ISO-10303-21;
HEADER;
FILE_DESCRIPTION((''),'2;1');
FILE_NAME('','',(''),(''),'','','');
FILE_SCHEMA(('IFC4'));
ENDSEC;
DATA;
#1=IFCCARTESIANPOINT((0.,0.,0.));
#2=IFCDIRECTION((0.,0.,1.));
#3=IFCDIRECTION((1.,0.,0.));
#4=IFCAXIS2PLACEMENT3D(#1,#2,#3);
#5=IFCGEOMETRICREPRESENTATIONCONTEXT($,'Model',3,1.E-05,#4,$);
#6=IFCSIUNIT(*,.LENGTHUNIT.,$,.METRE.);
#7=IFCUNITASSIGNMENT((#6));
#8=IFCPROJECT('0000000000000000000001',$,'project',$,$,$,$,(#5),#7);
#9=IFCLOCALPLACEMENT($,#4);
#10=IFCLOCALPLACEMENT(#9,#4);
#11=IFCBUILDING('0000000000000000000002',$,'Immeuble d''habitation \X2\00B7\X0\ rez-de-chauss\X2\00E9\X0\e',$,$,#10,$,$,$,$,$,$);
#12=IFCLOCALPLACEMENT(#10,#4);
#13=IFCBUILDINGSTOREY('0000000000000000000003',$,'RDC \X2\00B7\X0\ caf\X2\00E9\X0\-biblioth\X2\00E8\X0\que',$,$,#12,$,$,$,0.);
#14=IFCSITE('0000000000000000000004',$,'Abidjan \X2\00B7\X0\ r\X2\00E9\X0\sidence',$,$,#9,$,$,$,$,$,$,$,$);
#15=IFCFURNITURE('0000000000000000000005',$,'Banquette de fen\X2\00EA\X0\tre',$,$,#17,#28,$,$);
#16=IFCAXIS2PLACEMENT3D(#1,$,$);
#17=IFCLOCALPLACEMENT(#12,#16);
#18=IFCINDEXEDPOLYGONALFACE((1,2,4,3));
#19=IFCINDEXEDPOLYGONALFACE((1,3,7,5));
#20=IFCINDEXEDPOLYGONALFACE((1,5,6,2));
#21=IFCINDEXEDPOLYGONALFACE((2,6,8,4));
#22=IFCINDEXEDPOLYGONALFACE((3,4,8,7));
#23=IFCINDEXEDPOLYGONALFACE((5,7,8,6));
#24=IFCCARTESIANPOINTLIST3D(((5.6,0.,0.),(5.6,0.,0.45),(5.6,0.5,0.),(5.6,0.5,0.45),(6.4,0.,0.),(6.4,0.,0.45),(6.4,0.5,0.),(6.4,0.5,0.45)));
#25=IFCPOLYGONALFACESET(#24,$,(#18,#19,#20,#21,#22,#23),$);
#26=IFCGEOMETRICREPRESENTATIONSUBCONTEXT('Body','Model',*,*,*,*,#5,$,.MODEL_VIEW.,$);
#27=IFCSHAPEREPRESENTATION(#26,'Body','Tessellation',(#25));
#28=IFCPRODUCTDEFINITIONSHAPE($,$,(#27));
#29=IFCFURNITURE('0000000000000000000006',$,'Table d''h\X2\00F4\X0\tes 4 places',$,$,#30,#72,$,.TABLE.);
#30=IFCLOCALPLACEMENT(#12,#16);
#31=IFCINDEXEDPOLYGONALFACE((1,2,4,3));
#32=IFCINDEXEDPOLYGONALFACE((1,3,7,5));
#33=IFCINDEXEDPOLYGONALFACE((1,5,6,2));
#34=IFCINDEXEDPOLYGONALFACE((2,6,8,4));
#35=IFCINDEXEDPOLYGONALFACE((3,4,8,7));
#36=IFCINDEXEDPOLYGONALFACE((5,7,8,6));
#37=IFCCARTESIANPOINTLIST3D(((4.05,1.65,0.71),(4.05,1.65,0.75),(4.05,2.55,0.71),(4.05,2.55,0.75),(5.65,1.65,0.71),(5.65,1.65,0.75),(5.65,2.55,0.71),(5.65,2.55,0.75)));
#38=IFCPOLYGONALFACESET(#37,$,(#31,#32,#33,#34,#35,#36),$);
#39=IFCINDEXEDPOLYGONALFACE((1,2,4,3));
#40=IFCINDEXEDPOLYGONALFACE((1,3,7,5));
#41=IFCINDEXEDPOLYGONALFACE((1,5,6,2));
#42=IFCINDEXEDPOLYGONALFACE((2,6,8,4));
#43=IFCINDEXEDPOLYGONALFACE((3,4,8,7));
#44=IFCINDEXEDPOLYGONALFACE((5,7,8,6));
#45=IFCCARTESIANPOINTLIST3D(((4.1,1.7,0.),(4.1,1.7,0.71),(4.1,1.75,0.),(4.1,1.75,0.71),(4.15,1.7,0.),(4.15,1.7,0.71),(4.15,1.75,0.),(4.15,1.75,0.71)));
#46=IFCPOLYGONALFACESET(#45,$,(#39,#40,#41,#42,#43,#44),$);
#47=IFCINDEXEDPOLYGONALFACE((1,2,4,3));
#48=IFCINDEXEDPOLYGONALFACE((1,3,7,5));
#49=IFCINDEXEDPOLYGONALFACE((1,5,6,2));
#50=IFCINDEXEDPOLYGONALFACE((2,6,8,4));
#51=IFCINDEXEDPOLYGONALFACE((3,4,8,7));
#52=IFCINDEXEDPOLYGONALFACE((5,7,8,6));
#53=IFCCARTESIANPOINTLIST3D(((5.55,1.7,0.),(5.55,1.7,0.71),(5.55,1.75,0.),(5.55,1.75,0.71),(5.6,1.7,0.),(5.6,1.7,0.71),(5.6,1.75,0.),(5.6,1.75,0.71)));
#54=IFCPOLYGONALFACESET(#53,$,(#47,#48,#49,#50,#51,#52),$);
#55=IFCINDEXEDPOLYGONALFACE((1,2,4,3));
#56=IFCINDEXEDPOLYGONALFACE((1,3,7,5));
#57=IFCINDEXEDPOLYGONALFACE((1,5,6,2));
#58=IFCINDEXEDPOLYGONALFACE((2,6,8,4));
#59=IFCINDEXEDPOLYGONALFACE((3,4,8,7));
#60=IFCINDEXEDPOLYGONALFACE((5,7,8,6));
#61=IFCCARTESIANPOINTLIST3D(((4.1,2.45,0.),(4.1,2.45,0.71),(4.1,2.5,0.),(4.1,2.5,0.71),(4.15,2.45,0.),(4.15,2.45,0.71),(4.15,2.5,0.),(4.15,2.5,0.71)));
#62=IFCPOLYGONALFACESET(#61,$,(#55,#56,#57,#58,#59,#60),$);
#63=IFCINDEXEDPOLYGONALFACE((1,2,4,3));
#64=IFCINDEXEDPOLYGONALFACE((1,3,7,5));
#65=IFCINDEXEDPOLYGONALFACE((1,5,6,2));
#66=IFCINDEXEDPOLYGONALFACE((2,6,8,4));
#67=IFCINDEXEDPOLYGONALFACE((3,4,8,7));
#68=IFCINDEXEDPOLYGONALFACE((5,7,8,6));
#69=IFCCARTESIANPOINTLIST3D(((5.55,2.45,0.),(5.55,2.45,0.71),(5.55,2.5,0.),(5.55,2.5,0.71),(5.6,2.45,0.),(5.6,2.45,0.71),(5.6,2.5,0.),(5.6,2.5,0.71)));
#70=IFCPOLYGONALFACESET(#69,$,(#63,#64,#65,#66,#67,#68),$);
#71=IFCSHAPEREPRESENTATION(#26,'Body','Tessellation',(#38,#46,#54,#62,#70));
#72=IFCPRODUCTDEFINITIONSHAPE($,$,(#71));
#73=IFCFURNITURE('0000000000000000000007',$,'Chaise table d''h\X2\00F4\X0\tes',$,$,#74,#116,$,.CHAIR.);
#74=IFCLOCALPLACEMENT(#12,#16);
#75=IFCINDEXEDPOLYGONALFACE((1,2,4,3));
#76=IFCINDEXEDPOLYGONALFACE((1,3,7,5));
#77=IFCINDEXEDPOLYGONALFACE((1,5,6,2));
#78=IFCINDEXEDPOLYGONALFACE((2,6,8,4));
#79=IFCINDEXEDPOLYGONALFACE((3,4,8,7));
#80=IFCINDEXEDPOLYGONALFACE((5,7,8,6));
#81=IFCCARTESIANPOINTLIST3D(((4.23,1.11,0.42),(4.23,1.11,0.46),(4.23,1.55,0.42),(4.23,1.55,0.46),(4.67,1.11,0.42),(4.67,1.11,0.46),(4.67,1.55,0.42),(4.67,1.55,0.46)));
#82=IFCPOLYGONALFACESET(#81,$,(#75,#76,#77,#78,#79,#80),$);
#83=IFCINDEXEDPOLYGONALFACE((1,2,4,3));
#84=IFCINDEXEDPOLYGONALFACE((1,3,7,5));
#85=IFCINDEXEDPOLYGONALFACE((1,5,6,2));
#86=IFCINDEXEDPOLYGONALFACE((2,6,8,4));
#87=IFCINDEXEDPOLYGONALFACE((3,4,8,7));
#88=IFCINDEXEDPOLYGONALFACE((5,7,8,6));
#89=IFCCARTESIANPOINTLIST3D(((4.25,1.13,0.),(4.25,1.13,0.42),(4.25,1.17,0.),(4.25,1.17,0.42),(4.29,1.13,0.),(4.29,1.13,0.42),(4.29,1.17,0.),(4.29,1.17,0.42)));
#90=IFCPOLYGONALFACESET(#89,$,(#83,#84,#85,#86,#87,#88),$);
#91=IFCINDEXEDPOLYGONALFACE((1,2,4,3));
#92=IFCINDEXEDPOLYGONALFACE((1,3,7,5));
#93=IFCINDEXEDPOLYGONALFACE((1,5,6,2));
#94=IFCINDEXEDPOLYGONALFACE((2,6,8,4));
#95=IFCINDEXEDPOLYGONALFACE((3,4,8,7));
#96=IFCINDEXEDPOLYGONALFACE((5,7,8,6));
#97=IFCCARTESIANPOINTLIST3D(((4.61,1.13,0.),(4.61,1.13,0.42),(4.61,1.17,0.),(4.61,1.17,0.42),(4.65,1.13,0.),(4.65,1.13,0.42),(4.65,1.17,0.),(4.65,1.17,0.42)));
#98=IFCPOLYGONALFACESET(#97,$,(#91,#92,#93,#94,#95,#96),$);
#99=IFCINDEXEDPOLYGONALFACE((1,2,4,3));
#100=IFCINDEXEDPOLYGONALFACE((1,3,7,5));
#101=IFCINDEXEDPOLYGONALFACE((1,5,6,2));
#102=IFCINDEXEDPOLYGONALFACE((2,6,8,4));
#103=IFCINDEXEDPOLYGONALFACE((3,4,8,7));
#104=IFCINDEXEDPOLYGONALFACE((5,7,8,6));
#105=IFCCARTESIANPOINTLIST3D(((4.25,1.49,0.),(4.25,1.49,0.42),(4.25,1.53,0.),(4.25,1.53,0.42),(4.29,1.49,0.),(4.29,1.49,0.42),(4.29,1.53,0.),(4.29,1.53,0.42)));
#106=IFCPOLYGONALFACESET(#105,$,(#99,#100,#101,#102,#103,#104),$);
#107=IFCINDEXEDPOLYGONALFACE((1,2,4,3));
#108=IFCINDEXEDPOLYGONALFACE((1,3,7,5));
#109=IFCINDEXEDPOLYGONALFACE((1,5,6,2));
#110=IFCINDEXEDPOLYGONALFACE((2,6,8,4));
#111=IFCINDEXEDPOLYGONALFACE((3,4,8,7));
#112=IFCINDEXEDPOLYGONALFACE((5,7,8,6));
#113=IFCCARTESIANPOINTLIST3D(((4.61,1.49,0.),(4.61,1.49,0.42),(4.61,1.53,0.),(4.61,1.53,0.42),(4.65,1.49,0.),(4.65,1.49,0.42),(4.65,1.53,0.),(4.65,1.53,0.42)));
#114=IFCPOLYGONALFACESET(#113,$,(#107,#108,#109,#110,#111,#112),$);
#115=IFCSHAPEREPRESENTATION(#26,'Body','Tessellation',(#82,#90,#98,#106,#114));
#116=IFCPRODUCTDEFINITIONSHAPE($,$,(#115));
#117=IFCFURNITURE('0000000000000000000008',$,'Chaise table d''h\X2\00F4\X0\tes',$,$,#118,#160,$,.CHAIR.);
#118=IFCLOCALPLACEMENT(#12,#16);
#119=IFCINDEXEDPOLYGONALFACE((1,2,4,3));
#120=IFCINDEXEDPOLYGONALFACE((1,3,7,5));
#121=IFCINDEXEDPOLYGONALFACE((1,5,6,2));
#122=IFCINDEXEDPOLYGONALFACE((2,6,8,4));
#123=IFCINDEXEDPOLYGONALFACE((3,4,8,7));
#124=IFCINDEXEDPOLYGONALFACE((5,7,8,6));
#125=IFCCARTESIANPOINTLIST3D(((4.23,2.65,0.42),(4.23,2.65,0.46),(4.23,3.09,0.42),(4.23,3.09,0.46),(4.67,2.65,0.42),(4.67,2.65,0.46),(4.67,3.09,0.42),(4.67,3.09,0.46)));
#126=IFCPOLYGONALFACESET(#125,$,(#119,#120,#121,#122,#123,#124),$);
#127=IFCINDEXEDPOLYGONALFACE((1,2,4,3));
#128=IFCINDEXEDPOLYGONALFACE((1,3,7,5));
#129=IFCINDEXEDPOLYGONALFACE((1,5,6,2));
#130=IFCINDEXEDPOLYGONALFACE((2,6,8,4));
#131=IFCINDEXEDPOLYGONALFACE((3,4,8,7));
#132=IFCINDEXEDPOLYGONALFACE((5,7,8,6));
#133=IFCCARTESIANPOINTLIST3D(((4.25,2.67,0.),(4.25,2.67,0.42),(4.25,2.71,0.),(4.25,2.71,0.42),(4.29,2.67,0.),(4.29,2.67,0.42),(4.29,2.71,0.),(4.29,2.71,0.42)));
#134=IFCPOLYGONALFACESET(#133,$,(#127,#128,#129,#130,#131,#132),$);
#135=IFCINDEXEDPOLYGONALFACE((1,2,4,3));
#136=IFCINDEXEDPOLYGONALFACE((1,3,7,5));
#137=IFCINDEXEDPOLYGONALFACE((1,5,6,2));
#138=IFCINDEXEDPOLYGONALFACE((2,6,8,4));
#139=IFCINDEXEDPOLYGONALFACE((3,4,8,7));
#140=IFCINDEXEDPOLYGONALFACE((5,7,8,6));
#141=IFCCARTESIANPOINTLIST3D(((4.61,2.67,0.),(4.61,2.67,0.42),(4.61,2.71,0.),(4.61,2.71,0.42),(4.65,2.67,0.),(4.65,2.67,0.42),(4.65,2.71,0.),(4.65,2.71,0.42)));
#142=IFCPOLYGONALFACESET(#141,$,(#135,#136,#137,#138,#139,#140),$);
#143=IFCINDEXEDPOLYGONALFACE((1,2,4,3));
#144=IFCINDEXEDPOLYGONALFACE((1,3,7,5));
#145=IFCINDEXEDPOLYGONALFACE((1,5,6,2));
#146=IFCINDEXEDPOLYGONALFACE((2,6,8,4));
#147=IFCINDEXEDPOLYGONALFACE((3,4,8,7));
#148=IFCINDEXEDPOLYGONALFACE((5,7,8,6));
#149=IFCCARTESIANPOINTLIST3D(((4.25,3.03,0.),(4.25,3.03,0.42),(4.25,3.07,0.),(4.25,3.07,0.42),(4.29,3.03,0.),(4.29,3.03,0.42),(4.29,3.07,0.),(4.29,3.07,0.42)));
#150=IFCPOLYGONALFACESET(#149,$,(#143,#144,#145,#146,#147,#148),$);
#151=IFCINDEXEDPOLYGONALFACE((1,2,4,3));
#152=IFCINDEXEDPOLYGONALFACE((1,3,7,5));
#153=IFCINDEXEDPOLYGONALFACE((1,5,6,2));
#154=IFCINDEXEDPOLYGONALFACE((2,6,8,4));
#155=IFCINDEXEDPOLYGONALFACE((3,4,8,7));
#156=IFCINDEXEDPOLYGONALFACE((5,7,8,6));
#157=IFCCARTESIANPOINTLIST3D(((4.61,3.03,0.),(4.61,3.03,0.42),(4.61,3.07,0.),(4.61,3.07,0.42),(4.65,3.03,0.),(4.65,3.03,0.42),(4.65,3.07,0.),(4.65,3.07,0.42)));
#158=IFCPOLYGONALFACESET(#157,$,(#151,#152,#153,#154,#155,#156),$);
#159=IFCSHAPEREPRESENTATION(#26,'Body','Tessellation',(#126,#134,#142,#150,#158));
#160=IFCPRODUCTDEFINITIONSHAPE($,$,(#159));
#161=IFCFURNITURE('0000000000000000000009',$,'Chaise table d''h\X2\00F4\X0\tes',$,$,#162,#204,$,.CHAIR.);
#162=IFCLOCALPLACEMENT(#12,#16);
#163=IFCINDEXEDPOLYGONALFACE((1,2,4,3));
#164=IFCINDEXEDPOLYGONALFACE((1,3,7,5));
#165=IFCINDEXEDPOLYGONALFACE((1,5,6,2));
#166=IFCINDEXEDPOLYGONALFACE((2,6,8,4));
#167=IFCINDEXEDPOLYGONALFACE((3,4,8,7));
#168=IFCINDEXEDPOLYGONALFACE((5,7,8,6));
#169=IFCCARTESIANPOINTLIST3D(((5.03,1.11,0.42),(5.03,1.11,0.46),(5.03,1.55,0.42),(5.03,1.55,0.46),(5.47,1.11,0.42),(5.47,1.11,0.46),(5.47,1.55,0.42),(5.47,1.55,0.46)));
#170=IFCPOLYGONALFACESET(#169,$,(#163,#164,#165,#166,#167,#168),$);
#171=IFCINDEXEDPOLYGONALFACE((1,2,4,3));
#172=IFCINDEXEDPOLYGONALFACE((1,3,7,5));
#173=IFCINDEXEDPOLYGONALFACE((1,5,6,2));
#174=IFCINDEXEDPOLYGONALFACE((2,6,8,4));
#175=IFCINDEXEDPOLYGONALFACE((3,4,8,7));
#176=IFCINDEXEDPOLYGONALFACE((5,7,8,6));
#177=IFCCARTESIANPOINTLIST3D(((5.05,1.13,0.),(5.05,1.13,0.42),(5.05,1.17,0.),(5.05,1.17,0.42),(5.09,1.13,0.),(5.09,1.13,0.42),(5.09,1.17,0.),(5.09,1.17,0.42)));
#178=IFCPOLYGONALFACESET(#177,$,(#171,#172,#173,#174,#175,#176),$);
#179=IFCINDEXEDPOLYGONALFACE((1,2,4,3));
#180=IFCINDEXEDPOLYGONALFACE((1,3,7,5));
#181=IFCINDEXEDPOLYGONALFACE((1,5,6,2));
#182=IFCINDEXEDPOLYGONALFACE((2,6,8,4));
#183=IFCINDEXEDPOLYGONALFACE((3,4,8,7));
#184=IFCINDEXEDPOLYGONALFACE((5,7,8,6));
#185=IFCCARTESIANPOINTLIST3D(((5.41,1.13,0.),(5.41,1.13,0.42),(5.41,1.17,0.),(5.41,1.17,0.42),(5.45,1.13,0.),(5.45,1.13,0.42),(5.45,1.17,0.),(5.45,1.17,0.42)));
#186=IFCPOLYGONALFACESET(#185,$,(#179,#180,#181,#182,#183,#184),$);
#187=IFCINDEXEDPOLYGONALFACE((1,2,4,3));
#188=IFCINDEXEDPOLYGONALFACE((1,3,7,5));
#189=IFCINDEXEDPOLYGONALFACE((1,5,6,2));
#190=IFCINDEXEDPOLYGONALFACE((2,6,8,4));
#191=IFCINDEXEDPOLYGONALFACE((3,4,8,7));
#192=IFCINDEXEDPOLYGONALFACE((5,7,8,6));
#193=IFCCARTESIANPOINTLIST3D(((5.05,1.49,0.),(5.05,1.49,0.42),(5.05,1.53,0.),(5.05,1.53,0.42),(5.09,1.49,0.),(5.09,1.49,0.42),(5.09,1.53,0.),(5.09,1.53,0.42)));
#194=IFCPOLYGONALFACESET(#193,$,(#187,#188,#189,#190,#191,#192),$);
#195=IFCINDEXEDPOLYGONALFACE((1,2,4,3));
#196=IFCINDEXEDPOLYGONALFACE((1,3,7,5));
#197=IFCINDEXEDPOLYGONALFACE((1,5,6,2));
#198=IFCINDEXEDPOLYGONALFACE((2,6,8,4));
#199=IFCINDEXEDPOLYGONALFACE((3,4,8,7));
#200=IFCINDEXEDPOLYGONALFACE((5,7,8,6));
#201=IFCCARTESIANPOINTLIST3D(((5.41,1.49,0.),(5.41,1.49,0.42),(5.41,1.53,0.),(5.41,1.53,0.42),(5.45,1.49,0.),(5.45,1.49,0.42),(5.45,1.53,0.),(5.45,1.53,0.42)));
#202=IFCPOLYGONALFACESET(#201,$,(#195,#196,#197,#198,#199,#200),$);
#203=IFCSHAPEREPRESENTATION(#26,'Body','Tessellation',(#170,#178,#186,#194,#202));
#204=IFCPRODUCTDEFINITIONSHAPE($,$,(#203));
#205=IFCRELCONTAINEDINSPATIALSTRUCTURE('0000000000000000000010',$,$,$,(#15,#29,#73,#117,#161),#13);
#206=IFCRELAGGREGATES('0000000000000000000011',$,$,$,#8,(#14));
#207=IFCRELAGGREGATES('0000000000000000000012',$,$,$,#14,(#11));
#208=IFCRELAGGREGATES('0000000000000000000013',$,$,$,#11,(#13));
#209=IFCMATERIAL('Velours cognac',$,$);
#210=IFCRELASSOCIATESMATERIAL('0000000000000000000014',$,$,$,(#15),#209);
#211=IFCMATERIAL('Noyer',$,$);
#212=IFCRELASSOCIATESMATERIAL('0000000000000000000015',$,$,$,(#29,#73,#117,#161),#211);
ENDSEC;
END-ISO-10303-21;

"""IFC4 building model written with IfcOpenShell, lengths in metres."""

from ifc_helpers import new_model, si_unit, frame, frame_2d, origin, origin_with_axes, place, context, subcontext, project, spatial, rectangle, extrude, material, element, save


model = new_model("IFC4")

# Units and contexts
model_context = context("Model", 3, precision=1e-05, world=origin_with_axes())
body_context = subcontext(model_context, "Body", "Model", "MODEL_VIEW")
ifc_project = project(units=[si_unit("LENGTHUNIT", "METRE")], contexts=[model_context])

# Site, building, storey
site_placement = place(None, origin_with_axes())
site = spatial("IfcSite", under=ifc_project, at=site_placement, Name="Abidjan · résidence")
building_placement = place(site_placement, origin_with_axes())
building = spatial("IfcBuilding", under=site, at=building_placement, Name="Immeuble d'habitation · rez-de-chaussée")
storey_placement = place(building_placement, origin_with_axes())
storey = spatial("IfcBuildingStorey", under=building, at=storey_placement, Name="RDC · café-bibliothèque", Elevation=0.0)

# Furniture
ifc_material_1 = material(Name="Velours cognac")
ifc_material_2 = material(Name="Noyer")
furniture_1_placement = place(storey_placement, origin_with_axes())
element("IfcFurniture", 1, at=furniture_1_placement, inside=storey, material=ifc_material_1, Name="Banquette de fenêtre", context=body_context, shape_type="SweptSolid", body=[
    extrude(rectangle(XDim=0.8, YDim=0.5, at=frame_2d((6.0, 0.25))), origin(), (0.0, 0.0, 1.0), 0.45),
])
furniture_2_placement = place(storey_placement, origin_with_axes())
element("IfcFurniture", 2, at=furniture_2_placement, inside=storey, material=ifc_material_2, Name="Table d'hôtes 4 places", PredefinedType="TABLE", context=body_context, shape_type="SweptSolid", body=[
    extrude(rectangle(XDim=1.6, YDim=0.9, at=frame_2d((4.85, 2.1))), frame((0.0, 0.0, 0.71)), (0.0, 0.0, 1.0), 0.04),
    extrude(rectangle(XDim=0.05, YDim=0.05, at=frame_2d((4.125, 1.725))), origin(), (0.0, 0.0, 1.0), 0.71),
    extrude(rectangle(XDim=0.05, YDim=0.05, at=frame_2d((5.575, 1.725))), origin(), (0.0, 0.0, 1.0), 0.71),
    extrude(rectangle(XDim=0.05, YDim=0.05, at=frame_2d((4.125, 2.475))), origin(), (0.0, 0.0, 1.0), 0.71),
    extrude(rectangle(XDim=0.05, YDim=0.05, at=frame_2d((5.575, 2.475))), origin(), (0.0, 0.0, 1.0), 0.71),
])
furniture_3_placement = place(storey_placement, origin_with_axes())
element("IfcFurniture", 3, at=furniture_3_placement, inside=storey, material=ifc_material_2, Name="Chaise table d'hôtes", PredefinedType="CHAIR", context=body_context, shape_type="SweptSolid", body=[
    extrude(rectangle(XDim=0.44, YDim=0.44, at=frame_2d((4.45, 1.33))), frame((0.0, 0.0, 0.42)), (0.0, 0.0, 1.0), 0.04),
    extrude(rectangle(XDim=0.04, YDim=0.04, at=frame_2d((4.27, 1.15))), origin(), (0.0, 0.0, 1.0), 0.42),
    extrude(rectangle(XDim=0.04, YDim=0.04, at=frame_2d((4.63, 1.15))), origin(), (0.0, 0.0, 1.0), 0.42),
    extrude(rectangle(XDim=0.04, YDim=0.04, at=frame_2d((4.27, 1.51))), origin(), (0.0, 0.0, 1.0), 0.42),
    extrude(rectangle(XDim=0.04, YDim=0.04, at=frame_2d((4.63, 1.51))), origin(), (0.0, 0.0, 1.0), 0.42),
])
furniture_4_placement = place(storey_placement, origin_with_axes())
element("IfcFurniture", 4, at=furniture_4_placement, inside=storey, material=ifc_material_2, Name="Chaise table d'hôtes", PredefinedType="CHAIR", context=body_context, shape_type="SweptSolid", body=[
    extrude(rectangle(XDim=0.44, YDim=0.44, at=frame_2d((4.45, 2.87))), frame((0.0, 0.0, 0.42)), (0.0, 0.0, 1.0), 0.04),
    extrude(rectangle(XDim=0.04, YDim=0.04, at=frame_2d((4.27, 2.69))), origin(), (0.0, 0.0, 1.0), 0.42),
    extrude(rectangle(XDim=0.04, YDim=0.04, at=frame_2d((4.63, 2.69))), origin(), (0.0, 0.0, 1.0), 0.42),
    extrude(rectangle(XDim=0.04, YDim=0.04, at=frame_2d((4.27, 3.05))), origin(), (0.0, 0.0, 1.0), 0.42),
    extrude(rectangle(XDim=0.04, YDim=0.04, at=frame_2d((4.63, 3.05))), origin(), (0.0, 0.0, 1.0), 0.42),
])
furniture_5_placement = place(storey_placement, origin_with_axes())
element("IfcFurniture", 5, at=furniture_5_placement, inside=storey, material=ifc_material_2, Name="Chaise table d'hôtes", PredefinedType="CHAIR", context=body_context, shape_type="SweptSolid", body=[
    extrude(rectangle(XDim=0.44, YDim=0.44, at=frame_2d((5.25, 1.33))), frame((0.0, 0.0, 0.42)), (0.0, 0.0, 1.0), 0.04),
    extrude(rectangle(XDim=0.04, YDim=0.04, at=frame_2d((5.07, 1.15))), origin(), (0.0, 0.0, 1.0), 0.42),
    extrude(rectangle(XDim=0.04, YDim=0.04, at=frame_2d((5.43, 1.15))), origin(), (0.0, 0.0, 1.0), 0.42),
    extrude(rectangle(XDim=0.04, YDim=0.04, at=frame_2d((5.07, 1.51))), origin(), (0.0, 0.0, 1.0), 0.42),
    extrude(rectangle(XDim=0.04, YDim=0.04, at=frame_2d((5.43, 1.51))), origin(), (0.0, 0.0, 1.0), 0.42),
])

save(model, "model.ifc")
